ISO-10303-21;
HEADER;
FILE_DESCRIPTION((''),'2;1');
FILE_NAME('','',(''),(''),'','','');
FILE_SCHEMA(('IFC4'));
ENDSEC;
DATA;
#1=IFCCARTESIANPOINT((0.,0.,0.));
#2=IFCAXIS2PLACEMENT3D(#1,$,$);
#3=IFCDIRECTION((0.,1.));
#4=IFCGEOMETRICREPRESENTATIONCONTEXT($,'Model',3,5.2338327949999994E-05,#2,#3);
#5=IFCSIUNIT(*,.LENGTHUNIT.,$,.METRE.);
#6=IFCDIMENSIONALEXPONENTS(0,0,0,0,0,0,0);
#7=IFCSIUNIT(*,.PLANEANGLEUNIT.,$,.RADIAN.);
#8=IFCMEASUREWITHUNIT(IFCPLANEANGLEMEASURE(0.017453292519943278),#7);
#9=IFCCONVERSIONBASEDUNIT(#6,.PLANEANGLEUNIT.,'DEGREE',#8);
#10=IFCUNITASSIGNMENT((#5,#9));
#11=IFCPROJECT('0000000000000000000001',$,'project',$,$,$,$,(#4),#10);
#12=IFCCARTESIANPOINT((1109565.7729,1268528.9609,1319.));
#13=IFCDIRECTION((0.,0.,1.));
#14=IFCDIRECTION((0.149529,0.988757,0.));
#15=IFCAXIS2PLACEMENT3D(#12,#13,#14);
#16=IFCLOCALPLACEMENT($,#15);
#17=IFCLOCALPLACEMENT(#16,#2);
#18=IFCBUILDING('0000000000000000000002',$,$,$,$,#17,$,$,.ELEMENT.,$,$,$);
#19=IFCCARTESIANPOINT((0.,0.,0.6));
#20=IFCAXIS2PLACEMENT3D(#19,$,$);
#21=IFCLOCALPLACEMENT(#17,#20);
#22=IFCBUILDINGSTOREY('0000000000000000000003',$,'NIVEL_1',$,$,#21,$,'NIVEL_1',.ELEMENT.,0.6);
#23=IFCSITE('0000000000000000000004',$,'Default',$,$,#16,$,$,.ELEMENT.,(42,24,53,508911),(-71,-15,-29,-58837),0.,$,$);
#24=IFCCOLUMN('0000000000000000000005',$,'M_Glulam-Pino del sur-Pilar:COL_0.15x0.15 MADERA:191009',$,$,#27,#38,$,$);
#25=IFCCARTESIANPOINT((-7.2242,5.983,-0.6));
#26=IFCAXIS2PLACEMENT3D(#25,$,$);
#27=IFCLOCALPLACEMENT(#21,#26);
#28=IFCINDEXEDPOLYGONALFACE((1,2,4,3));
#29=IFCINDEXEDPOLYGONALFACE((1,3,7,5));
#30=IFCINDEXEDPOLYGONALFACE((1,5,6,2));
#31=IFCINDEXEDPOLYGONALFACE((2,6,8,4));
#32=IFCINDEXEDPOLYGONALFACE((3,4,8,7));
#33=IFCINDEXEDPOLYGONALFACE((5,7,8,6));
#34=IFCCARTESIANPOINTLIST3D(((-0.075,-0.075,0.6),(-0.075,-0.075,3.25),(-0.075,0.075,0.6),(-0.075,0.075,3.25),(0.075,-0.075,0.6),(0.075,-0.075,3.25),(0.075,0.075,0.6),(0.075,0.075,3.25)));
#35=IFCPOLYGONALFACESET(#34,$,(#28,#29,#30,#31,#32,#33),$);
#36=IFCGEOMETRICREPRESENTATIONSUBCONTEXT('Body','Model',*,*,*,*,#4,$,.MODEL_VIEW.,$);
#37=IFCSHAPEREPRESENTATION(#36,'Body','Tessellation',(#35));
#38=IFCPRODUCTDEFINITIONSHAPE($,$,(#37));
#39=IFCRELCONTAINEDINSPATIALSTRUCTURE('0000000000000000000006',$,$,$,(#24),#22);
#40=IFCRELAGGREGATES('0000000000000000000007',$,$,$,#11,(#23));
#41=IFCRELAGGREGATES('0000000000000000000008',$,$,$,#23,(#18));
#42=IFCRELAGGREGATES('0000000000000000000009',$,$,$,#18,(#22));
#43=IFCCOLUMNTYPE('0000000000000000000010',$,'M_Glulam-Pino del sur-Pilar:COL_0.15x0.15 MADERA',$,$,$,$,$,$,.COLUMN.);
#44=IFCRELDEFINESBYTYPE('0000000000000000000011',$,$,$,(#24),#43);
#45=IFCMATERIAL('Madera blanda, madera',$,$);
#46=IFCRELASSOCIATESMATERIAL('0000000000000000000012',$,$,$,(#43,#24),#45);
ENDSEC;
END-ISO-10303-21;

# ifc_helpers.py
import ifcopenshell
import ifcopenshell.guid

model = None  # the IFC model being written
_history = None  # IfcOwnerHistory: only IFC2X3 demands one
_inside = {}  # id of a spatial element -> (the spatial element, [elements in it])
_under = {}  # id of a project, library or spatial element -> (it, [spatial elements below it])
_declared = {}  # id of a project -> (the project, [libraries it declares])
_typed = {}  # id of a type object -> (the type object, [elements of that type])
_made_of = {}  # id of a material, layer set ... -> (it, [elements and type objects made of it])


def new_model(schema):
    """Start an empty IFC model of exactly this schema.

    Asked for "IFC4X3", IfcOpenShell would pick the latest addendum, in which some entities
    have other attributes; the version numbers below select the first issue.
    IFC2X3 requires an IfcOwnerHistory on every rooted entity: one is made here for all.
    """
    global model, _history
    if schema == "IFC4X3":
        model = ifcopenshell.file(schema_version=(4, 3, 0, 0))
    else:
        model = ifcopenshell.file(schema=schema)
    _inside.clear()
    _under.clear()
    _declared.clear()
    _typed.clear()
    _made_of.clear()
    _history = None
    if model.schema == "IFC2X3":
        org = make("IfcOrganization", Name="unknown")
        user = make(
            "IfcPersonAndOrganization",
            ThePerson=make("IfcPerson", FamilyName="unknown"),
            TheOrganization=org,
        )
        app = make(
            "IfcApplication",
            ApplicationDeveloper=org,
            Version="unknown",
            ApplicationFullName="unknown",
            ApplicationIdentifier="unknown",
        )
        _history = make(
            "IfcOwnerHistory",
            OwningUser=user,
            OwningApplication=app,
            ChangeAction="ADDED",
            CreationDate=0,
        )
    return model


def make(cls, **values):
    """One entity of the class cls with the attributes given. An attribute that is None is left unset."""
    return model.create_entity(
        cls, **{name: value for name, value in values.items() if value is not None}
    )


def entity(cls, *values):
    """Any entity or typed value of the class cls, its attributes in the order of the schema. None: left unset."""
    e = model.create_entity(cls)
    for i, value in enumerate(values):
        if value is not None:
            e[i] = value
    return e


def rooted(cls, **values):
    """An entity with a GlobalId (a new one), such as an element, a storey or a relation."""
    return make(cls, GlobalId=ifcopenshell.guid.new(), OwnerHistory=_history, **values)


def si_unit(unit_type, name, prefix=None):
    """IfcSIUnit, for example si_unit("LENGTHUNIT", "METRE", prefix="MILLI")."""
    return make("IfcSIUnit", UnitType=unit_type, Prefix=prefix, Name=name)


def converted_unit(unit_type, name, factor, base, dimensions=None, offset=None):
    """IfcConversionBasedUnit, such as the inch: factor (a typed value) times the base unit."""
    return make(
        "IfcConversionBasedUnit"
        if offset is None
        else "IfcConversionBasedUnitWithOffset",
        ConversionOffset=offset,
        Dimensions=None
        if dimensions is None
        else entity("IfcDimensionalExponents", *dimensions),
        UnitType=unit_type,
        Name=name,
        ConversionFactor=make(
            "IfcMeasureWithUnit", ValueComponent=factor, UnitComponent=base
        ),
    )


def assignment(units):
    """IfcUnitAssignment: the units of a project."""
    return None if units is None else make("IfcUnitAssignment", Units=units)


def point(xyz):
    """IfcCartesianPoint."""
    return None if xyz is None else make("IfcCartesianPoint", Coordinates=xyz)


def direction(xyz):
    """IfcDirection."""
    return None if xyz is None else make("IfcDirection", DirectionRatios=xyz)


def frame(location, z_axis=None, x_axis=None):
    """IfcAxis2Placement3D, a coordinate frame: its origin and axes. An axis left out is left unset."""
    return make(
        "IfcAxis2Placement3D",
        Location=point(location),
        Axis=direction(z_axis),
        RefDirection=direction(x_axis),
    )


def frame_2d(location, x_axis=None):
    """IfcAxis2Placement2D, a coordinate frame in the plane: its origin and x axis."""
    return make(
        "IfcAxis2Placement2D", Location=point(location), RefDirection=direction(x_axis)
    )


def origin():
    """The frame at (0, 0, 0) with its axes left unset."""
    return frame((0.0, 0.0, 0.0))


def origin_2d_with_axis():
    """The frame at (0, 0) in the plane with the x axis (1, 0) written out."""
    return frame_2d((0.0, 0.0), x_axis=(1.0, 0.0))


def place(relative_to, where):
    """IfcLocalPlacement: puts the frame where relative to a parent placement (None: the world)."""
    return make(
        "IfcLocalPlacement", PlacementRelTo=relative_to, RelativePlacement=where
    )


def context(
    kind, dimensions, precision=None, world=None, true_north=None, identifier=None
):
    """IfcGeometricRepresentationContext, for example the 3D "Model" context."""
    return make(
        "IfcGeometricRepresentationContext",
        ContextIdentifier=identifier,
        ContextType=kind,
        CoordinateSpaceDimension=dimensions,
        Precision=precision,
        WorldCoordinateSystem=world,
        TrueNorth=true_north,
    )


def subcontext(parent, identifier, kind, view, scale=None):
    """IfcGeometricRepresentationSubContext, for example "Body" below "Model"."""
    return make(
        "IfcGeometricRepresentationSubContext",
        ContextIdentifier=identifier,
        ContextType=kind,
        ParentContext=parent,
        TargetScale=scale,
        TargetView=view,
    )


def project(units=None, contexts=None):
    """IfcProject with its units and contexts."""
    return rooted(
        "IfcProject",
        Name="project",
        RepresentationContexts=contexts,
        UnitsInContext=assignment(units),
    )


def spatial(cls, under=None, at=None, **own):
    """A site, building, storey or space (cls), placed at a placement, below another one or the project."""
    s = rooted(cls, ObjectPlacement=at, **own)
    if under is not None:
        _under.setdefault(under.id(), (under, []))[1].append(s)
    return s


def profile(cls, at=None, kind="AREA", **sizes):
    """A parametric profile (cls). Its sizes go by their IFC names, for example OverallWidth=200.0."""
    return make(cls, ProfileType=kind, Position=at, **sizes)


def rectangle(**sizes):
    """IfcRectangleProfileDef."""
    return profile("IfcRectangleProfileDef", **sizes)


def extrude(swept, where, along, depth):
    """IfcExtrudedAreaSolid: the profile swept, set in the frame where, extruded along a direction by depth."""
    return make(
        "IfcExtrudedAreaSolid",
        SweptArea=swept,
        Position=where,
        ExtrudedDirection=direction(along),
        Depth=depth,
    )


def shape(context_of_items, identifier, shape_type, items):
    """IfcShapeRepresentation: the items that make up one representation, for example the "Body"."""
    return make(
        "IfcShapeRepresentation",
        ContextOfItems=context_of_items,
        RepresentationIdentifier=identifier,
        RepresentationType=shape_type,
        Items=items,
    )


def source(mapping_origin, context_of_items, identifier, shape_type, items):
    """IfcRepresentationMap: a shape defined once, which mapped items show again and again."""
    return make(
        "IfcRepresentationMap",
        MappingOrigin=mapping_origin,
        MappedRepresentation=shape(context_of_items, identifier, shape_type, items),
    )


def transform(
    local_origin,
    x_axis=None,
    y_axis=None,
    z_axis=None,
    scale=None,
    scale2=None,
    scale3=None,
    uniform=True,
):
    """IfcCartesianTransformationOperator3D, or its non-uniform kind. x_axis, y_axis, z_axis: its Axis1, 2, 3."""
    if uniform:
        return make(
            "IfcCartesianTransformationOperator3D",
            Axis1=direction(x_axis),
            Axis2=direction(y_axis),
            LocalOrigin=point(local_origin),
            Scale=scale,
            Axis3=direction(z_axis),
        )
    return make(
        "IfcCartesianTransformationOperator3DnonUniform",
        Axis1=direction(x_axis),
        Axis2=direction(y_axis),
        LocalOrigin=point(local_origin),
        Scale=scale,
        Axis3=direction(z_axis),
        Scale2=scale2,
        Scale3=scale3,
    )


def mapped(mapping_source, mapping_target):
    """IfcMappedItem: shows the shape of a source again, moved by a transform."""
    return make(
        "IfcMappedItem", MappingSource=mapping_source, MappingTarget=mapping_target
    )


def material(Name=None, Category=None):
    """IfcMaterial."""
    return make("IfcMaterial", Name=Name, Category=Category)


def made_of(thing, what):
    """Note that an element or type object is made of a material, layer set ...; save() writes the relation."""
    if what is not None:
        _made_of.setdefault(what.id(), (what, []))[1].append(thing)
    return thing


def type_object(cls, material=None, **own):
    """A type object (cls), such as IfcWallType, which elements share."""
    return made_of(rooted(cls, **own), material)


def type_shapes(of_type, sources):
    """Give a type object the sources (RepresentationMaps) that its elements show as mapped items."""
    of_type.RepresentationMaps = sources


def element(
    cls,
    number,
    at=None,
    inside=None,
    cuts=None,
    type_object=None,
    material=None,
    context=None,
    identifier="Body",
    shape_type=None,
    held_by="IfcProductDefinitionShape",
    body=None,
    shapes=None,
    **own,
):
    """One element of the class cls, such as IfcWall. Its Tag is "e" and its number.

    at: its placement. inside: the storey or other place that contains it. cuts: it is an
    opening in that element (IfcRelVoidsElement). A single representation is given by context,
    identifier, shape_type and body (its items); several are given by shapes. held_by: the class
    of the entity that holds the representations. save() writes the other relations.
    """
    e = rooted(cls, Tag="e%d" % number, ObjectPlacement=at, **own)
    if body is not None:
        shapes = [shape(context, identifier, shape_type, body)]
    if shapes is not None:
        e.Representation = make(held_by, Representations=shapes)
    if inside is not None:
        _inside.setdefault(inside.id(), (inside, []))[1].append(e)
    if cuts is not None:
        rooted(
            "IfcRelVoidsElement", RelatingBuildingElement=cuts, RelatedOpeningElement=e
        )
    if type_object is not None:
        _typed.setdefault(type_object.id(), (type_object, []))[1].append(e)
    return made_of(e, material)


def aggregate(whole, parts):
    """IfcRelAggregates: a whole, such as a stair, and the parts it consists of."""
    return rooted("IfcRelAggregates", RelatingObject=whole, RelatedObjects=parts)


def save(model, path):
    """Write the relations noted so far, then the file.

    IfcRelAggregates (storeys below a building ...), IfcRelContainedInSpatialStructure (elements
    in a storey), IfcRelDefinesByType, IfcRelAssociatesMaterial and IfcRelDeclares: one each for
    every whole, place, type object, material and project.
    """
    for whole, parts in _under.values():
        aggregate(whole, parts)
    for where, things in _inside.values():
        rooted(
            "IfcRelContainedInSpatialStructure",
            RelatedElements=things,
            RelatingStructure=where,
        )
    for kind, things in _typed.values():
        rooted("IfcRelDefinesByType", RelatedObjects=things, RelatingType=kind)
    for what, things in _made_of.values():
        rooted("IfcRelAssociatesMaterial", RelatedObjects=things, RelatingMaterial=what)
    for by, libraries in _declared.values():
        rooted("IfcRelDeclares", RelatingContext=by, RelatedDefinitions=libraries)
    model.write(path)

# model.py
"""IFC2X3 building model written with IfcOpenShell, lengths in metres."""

from ifc_helpers import new_model, entity, si_unit, converted_unit, direction, frame, origin, origin_2d_with_axis, place, context, subcontext, project, spatial, rectangle, extrude, source, transform, mapped, material, type_object, type_shapes, element, save


model = new_model("IFC2X3")

# Units and contexts
model_context = context("Model", 3, precision=5.2338327949999994e-05, world=origin(), true_north=direction((0.0, 1.0)))
body_context = subcontext(model_context, "Body", "Model", "MODEL_VIEW")
ifc_project = project(units=[si_unit("LENGTHUNIT", "METRE"), converted_unit("PLANEANGLEUNIT", "DEGREE", entity("IfcPlaneAngleMeasure", 0.017453292519943278), si_unit("PLANEANGLEUNIT", "RADIAN"), dimensions=[0, 0, 0, 0, 0, 0, 0])], contexts=[model_context])

# Site, building, storey
site_placement = place(None, frame((1109565.7729, 1268528.9609, 1319.0), z_axis=(0.0, 0.0, 1.0), x_axis=(0.149529, 0.988757, 0.0)))
site = spatial("IfcSite", under=ifc_project, at=site_placement, Name="Default", CompositionType="ELEMENT", RefLatitude=(42, 24, 53, 508911), RefLongitude=(-71, -15, -29, -58837), RefElevation=0.0)
building_placement = place(site_placement, origin())
building = spatial("IfcBuilding", under=site, at=building_placement, CompositionType="ELEMENT")
storey_placement = place(building_placement, frame((0.0, 0.0, 0.6)))
storey = spatial("IfcBuildingStorey", under=building, at=storey_placement, Name="NIVEL_1", LongName="NIVEL_1", CompositionType="ELEMENT", Elevation=0.6)

# Column
ifc_material_1 = material(Name="Madera blanda, madera")
column_type = type_object("IfcColumnType", Name="M_Glulam-Pino del sur-Pilar:COL_0.15x0.15 MADERA", PredefinedType="COLUMN", material=ifc_material_1)
shared_shape_1 = source(origin(), body_context, "Body", "SweptSolid", [
    extrude(rectangle(XDim=0.15, YDim=0.15, at=origin_2d_with_axis()), frame((0.0, 0.0, 0.6), z_axis=(0.0, 0.0, 1.0), x_axis=(-1.0, 0.0, 0.0)), (0.0, 0.0, 1.0), 2.65),
])
type_shapes(column_type, [shared_shape_1])
column_placement = place(storey_placement, frame((-7.2242, 5.983, -0.6)))
element("IfcColumn", 1, at=column_placement, inside=storey, type_object=column_type, material=ifc_material_1, Name="M_Glulam-Pino del sur-Pilar:COL_0.15x0.15 MADERA:191009", context=body_context, shape_type="MappedRepresentation", body=[
    mapped(shared_shape_1, transform((0.0, 0.0, 0.0), scale=1.0)),
])

save(model, "model.ifc")
